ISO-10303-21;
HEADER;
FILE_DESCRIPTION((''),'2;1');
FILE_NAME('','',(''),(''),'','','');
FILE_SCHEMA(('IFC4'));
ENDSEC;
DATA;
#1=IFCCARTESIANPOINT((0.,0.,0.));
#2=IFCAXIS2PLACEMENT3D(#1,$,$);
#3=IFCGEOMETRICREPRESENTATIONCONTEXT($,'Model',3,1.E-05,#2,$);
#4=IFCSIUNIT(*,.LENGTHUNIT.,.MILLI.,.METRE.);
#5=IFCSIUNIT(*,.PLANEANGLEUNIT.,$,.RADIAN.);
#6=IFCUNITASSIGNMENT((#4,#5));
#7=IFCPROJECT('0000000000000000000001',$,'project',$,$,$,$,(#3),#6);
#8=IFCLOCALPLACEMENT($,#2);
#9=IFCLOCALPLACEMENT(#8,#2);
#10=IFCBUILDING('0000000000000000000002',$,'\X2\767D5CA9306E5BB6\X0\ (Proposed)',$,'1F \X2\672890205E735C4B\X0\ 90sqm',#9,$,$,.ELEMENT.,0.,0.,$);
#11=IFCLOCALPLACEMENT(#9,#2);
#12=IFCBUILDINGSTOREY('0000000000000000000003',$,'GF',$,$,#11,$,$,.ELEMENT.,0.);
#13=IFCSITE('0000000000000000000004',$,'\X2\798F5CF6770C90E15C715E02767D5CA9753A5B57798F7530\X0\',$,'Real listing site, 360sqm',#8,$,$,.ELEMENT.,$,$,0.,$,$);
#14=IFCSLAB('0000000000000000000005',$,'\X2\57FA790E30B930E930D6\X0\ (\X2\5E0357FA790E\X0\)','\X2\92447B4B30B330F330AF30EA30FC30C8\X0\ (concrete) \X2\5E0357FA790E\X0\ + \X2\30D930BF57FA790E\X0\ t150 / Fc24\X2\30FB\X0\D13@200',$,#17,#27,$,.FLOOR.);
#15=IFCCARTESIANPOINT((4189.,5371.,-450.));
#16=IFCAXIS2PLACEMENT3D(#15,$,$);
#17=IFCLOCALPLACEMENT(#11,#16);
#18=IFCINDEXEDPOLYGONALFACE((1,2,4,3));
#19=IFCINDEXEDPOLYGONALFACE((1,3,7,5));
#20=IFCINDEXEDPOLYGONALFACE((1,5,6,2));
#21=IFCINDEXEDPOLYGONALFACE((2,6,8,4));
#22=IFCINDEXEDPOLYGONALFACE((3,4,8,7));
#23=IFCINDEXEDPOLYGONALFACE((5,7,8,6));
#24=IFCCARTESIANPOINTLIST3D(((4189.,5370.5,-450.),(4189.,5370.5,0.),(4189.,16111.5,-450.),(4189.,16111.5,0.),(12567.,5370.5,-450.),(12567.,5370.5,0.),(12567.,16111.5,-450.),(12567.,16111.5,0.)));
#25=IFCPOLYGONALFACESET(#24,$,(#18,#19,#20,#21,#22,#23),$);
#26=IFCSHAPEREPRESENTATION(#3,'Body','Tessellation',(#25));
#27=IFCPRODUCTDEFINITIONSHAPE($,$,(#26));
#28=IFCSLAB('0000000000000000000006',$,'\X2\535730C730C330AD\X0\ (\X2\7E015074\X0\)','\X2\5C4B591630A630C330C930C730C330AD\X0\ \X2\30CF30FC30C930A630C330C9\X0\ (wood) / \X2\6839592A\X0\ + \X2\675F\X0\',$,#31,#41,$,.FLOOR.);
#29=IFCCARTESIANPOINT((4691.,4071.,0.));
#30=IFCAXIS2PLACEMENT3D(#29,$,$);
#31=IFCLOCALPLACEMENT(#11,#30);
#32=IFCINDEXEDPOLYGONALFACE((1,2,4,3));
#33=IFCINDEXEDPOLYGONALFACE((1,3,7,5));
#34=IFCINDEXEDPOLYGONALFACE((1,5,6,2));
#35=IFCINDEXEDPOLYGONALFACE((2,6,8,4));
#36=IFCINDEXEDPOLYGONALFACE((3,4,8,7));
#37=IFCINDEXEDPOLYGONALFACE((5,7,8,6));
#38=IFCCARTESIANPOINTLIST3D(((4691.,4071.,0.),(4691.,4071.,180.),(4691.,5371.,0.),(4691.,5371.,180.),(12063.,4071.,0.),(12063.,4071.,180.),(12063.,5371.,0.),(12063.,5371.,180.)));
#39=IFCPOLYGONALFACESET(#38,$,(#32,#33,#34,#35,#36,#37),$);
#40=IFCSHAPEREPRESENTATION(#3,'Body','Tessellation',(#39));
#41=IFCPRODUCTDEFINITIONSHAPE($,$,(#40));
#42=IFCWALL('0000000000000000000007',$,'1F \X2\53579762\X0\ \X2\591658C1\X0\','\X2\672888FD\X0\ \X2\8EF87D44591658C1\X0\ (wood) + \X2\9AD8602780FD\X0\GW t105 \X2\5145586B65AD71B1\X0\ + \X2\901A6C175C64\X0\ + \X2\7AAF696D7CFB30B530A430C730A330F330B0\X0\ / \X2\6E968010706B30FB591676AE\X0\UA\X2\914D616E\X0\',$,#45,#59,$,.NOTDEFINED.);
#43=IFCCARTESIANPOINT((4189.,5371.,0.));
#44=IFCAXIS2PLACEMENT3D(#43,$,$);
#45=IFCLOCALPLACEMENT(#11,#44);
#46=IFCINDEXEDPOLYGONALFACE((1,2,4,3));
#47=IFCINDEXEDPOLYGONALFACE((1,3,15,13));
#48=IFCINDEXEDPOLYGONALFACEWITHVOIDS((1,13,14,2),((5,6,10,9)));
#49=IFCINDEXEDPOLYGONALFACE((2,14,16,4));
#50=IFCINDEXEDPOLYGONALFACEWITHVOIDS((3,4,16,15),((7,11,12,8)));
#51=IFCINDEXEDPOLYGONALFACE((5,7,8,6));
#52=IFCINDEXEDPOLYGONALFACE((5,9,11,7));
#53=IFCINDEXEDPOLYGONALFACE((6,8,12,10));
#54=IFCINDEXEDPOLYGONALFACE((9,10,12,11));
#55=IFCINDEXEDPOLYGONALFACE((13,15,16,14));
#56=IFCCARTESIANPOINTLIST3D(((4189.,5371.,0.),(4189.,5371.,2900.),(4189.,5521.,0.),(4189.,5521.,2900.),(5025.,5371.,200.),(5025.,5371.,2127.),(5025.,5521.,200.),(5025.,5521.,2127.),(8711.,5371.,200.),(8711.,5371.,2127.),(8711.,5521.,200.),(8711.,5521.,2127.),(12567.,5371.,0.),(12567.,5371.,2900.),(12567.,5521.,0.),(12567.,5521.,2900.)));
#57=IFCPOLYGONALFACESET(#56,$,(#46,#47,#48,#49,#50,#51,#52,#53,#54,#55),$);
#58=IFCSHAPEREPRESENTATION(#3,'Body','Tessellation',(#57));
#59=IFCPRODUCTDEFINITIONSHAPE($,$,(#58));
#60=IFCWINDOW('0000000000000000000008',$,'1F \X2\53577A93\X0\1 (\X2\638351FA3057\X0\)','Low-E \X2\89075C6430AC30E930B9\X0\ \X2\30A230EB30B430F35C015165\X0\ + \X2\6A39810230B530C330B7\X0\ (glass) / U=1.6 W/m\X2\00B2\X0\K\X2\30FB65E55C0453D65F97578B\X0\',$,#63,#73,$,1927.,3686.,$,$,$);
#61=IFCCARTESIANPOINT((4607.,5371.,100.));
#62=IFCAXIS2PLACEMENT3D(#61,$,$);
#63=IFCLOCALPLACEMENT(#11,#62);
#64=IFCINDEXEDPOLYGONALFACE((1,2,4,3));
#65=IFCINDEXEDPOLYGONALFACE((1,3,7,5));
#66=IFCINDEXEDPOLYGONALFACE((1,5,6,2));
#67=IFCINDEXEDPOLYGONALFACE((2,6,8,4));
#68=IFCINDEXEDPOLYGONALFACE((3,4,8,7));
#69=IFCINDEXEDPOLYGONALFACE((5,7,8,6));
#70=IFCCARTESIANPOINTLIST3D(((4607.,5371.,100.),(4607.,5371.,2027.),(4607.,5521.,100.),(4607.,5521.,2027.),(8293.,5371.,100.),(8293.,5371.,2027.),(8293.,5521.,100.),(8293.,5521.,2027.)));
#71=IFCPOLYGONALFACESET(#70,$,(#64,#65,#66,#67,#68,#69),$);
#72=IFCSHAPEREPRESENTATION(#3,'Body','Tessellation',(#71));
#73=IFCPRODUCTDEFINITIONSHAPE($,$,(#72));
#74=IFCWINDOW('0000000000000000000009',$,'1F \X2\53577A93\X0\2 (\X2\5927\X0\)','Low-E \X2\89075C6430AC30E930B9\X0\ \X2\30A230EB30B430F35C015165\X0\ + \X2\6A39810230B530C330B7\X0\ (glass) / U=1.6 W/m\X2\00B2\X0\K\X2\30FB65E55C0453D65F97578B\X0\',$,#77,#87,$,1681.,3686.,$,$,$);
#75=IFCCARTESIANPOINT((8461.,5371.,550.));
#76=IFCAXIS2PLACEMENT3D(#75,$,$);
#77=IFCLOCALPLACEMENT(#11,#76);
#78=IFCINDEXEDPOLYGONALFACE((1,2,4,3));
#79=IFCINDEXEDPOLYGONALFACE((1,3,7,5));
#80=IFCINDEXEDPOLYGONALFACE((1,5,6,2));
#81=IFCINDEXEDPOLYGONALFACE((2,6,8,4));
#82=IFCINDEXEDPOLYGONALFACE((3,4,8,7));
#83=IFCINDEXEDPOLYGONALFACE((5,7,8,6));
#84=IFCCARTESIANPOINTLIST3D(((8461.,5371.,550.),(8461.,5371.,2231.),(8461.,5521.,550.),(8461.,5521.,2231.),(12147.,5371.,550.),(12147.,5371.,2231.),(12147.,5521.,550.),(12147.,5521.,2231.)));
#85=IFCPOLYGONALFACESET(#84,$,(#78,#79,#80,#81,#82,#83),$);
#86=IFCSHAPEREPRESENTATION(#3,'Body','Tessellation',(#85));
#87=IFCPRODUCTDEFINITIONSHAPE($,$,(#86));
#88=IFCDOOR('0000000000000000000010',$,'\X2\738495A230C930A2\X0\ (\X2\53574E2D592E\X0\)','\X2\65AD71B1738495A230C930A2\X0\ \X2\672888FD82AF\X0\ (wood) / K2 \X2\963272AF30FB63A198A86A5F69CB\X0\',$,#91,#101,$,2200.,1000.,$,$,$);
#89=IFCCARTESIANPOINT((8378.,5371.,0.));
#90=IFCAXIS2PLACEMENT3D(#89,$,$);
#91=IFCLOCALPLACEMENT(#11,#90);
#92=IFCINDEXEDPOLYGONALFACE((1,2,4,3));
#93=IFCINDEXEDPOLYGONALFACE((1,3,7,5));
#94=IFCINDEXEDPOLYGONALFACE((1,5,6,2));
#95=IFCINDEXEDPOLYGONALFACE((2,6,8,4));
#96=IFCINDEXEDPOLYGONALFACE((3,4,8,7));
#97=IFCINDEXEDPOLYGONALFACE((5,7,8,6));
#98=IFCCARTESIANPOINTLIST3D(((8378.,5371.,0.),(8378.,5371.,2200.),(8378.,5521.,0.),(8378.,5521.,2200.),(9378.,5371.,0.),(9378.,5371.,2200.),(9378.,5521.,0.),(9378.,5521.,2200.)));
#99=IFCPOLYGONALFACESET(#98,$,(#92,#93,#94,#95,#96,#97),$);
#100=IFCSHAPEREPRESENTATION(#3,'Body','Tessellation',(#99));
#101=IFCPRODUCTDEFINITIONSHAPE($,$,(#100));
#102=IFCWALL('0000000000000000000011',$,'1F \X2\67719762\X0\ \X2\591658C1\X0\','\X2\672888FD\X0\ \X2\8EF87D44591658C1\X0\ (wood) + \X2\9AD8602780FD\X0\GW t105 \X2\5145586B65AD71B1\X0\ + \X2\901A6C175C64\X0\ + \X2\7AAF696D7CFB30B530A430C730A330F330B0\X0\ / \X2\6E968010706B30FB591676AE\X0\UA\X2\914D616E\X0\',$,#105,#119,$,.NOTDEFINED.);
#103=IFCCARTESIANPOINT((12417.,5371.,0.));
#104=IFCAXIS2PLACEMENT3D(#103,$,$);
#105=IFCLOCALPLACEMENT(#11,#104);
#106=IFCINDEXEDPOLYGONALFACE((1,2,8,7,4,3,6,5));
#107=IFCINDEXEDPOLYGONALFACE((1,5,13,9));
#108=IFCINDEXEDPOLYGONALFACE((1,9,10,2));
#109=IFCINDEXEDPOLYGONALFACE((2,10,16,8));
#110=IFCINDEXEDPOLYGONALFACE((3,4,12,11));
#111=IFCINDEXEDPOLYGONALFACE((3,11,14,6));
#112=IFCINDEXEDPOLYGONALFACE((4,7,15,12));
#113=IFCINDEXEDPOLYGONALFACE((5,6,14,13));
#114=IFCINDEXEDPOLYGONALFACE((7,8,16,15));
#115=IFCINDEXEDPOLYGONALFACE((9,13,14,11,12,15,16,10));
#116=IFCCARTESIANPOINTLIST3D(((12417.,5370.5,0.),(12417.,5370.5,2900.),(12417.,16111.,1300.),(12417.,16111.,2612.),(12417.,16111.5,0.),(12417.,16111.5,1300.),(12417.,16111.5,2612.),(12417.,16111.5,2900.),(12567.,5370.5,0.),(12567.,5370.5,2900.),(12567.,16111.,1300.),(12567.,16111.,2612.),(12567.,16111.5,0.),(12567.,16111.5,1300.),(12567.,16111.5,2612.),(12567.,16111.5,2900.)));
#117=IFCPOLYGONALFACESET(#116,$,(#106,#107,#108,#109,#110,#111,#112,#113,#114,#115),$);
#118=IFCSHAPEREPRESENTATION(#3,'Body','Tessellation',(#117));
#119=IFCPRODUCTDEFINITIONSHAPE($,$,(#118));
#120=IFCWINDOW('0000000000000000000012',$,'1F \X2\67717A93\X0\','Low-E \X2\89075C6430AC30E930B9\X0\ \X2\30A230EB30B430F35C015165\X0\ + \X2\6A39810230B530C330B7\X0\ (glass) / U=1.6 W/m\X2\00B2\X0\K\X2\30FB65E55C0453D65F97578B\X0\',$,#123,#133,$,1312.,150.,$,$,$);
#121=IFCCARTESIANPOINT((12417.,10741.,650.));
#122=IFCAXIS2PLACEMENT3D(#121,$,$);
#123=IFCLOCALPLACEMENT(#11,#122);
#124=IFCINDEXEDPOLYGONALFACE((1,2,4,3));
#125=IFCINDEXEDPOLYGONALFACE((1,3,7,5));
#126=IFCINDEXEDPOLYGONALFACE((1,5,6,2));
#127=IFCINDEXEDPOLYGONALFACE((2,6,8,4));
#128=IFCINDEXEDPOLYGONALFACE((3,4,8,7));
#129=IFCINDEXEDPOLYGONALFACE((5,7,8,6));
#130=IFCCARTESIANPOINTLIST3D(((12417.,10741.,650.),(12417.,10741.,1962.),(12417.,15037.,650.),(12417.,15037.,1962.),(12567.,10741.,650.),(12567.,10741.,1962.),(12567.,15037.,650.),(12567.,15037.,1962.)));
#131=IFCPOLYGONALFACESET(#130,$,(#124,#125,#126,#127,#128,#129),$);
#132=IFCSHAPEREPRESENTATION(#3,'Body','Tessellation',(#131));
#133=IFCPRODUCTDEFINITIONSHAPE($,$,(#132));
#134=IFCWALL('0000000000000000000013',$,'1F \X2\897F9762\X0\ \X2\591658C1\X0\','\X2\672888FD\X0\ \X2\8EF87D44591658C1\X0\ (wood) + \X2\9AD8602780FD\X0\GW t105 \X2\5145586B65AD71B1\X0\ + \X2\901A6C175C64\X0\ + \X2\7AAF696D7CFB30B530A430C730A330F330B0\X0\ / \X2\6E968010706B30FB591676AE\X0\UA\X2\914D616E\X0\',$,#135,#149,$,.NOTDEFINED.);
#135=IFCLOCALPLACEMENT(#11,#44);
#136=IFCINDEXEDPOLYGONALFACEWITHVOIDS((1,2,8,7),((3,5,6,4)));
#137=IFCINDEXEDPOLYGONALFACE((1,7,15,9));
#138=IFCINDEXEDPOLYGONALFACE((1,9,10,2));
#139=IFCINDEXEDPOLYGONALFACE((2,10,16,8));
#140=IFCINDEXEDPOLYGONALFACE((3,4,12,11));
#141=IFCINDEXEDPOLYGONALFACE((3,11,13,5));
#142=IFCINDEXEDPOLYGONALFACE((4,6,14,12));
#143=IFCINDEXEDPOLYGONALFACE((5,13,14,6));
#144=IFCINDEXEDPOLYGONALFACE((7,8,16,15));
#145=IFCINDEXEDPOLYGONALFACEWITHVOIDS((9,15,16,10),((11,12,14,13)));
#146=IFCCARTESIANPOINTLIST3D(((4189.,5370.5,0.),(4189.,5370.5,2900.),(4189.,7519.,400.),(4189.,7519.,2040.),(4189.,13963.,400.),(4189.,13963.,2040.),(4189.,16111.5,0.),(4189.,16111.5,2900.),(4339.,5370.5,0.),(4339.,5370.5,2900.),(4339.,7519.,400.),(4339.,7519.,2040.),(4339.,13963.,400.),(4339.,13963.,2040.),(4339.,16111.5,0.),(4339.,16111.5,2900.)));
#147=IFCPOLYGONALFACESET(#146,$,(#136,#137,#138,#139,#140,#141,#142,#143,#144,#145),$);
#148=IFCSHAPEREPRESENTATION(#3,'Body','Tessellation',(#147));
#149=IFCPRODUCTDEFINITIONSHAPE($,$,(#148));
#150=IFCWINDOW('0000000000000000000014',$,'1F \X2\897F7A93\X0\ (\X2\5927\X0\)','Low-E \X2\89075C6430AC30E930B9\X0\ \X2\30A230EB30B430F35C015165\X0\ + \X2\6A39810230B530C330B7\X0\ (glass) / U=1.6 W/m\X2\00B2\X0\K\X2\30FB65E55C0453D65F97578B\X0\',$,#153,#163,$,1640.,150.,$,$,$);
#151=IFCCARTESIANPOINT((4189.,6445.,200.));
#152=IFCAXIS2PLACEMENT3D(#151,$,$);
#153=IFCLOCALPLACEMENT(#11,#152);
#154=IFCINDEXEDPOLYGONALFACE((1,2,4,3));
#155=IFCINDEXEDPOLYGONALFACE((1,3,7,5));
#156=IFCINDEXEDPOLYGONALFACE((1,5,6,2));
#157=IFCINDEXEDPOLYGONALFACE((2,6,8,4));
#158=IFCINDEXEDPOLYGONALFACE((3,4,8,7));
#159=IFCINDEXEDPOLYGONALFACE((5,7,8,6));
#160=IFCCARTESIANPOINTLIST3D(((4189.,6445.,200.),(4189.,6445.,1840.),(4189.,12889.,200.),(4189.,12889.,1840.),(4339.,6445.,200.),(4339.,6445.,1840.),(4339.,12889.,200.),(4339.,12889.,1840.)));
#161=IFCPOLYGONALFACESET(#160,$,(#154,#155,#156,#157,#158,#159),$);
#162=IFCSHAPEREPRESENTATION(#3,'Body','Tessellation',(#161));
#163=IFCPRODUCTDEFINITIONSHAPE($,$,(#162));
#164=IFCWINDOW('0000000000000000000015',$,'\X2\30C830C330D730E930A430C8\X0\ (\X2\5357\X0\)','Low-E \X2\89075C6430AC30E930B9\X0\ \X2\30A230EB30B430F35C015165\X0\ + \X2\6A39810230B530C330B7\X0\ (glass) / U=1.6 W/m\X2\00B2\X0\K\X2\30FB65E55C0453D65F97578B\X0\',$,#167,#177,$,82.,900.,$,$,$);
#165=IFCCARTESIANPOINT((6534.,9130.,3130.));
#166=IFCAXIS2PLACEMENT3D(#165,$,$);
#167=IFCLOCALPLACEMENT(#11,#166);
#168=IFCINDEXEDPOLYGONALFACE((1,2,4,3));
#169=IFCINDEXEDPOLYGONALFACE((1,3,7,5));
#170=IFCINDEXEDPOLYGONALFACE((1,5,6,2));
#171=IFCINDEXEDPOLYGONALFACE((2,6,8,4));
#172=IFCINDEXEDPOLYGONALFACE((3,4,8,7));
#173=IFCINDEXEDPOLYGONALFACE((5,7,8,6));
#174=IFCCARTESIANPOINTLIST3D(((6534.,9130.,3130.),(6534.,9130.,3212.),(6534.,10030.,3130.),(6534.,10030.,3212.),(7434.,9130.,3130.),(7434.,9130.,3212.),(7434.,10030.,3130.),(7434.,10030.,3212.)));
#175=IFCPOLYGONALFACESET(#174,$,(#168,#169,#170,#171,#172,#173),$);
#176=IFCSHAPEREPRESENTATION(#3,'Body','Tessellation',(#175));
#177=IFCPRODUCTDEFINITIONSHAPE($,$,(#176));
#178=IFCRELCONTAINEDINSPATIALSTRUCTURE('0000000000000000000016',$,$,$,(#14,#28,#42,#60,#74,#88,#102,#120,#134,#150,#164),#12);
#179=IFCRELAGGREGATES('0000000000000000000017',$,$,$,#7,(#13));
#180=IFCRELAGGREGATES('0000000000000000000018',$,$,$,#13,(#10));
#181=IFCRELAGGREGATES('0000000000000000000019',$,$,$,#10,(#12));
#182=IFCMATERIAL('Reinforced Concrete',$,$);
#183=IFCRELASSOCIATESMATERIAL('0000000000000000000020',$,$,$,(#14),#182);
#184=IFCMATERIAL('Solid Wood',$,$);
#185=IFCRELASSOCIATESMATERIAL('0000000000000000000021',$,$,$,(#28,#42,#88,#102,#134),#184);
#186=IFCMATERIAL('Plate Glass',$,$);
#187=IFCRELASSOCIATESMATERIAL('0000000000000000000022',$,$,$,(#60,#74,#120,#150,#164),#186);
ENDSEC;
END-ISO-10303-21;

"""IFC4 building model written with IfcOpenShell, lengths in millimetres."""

from ifc_helpers import new_model, si_unit, frame, frame_2d, origin, place, context, project, spatial, rectangle, extrude, material, element, fill, save


model = new_model("IFC4")

# Units and contexts
model_context = context("Model", 3, precision=1e-05, world=origin())
ifc_project = project(units=[si_unit("LENGTHUNIT", "METRE", prefix="MILLI"), si_unit("PLANEANGLEUNIT", "RADIAN")], contexts=[model_context])

# Site, building, storey
site_placement = place(None, origin())
site = spatial("IfcSite", under=ifc_project, at=site_placement, Name="福島県郡山市白岩町字福田", ObjectType="Real listing site, 360sqm", CompositionType="ELEMENT", RefElevation=0.0)
building_placement = place(site_placement, origin())
building = spatial("IfcBuilding", under=site, at=building_placement, Name="白岩の家 (Proposed)", ObjectType="1F 木造平屋 90sqm", CompositionType="ELEMENT", ElevationOfRefHeight=0.0, ElevationOfTerrain=0.0)
storey_placement = place(building_placement, origin())
storey = spatial("IfcBuildingStorey", under=building, at=storey_placement, Name="GF", CompositionType="ELEMENT", Elevation=0.0)

# Slabs
ifc_material_1 = material(Name="Reinforced Concrete")
slab_1_placement = place(storey_placement, frame((4189.0, 5371.0, -450.0)))
element("IfcSlab", 1, at=slab_1_placement, inside=storey, material=ifc_material_1, Name="基礎スラブ (布基礎)", Description="鉄筋コンクリート (concrete) 布基礎 + ベタ基礎 t150 / Fc24・D13@200", PredefinedType="FLOOR", context=model_context, shape_type="SweptSolid", body=[
    extrude(rectangle(XDim=8378.0, YDim=10741.0, at=frame_2d((4189.0, 5370.0))), frame((4189.0, 5371.0, -450.0)), (0.0, 0.0, 1.0), 450.0),
])
ifc_material_2 = material(Name="Solid Wood")
slab_2_placement = place(storey_placement, frame((4691.0, 4071.0, 0.0)))
element("IfcSlab", 2, at=slab_2_placement, inside=storey, material=ifc_material_2, Name="南デッキ (縁側)", Description="屋外ウッドデッキ ハードウッド (wood) / 根太 + 束", PredefinedType="FLOOR", context=model_context, shape_type="SweptSolid", body=[
    extrude(rectangle(XDim=7372.0, YDim=1300.0, at=frame_2d((3686.0, 650.0))), frame((4691.0, 4071.0, 0.0)), (0.0, 0.0, 1.0), 180.0),
])

# Wall, openings, windows, door
wall_1_placement = place(storey_placement, frame((4189.0, 5371.0, 0.0)))
wall_1 = element("IfcWall", 3, at=wall_1_placement, inside=storey, material=ifc_material_2, Name="1F 南面 外壁", Description="木製 軸組外壁 (wood) + 高性能GW t105 充填断熱 + 通気層 + 窯業系サイディング / 準耐火・外皮UA配慮", PredefinedType="NOTDEFINED", context=model_context, shape_type="SweptSolid", body=[
    extrude(rectangle(XDim=8378.0, YDim=150.0, at=frame_2d((4189.0, 75.0))), frame((4189.0, 5371.0, 0.0)), (0.0, 0.0, 1.0), 2900.0),
])
opening_1_placement = place(storey_placement, frame((4607.0, 5371.0, 100.0)))
opening_1 = element("IfcOpeningElement", 4, at=opening_1_placement, cuts=wall_1, PredefinedType="NOTDEFINED", context=model_context, shape_type="SweptSolid", body=[
    extrude(rectangle(XDim=3686.0, YDim=150.0, at=frame_2d((1843.0, 75.0))), frame((4607.0, 5371.0, 100.0)), (0.0, 0.0, 1.0), 1927.0),
])
opening_2_placement = place(storey_placement, frame((8461.0, 5371.0, 550.0)))
opening_2 = element("IfcOpeningElement", 5, at=opening_2_placement, cuts=wall_1, PredefinedType="NOTDEFINED", context=model_context, shape_type="SweptSolid", body=[
    extrude(rectangle(XDim=3686.0, YDim=150.0, at=frame_2d((1843.0, 75.0))), frame((8461.0, 5371.0, 550.0)), (0.0, 0.0, 1.0), 1681.0),
])
opening_3_placement = place(storey_placement, frame((8378.0, 5371.0, 0.0)))
opening_3 = element("IfcOpeningElement", 6, at=opening_3_placement, cuts=wall_1, PredefinedType="NOTDEFINED", context=model_context, shape_type="SweptSolid", body=[
    extrude(rectangle(XDim=1000.0, YDim=150.0, at=frame_2d((500.0, 75.0))), frame((8378.0, 5371.0, 0.0)), (0.0, 0.0, 1.0), 2200.0),
])
ifc_material_3 = material(Name="Plate Glass")
window_1_placement = place(storey_placement, frame((4607.0, 5371.0, 100.0)))
window_1 = element("IfcWindow", 7, at=window_1_placement, inside=storey, material=ifc_material_3, Name="1F 南窓1 (掃出し)", Description="Low-E 複層ガラス アルゴン封入 + 樹脂サッシ (glass) / U=1.6 W/m²K・日射取得型", OverallHeight=1927.0, OverallWidth=3686.0, context=model_context, shape_type="SweptSolid", body=[
    extrude(rectangle(XDim=3686.0, YDim=150.0, at=frame_2d((1843.0, 75.0))), frame((4607.0, 5371.0, 100.0)), (0.0, 0.0, 1.0), 1927.0),
])
fill(opening_1, window_1)
window_2_placement = place(storey_placement, frame((8461.0, 5371.0, 550.0)))
window_2 = element("IfcWindow", 8, at=window_2_placement, inside=storey, material=ifc_material_3, Name="1F 南窓2 (大)", Description="Low-E 複層ガラス アルゴン封入 + 樹脂サッシ (glass) / U=1.6 W/m²K・日射取得型", OverallHeight=1681.0, OverallWidth=3686.0, context=model_context, shape_type="SweptSolid", body=[
    extrude(rectangle(XDim=3686.0, YDim=150.0, at=frame_2d((1843.0, 75.0))), frame((8461.0, 5371.0, 550.0)), (0.0, 0.0, 1.0), 1681.0),
])
fill(opening_2, window_2)
door_placement = place(storey_placement, frame((8378.0, 5371.0, 0.0)))
door = element("IfcDoor", 9, at=door_placement, inside=storey, material=ifc_material_2, Name="玄関ドア (南中央)", Description="断熱玄関ドア 木製芯 (wood) / K2 防犯・採風機構", OverallHeight=2200.0, OverallWidth=1000.0, context=model_context, shape_type="SweptSolid", body=[
    extrude(rectangle(XDim=1000.0, YDim=150.0, at=frame_2d((500.0, 75.0))), frame((8378.0, 5371.0, 0.0)), (0.0, 0.0, 1.0), 2200.0),
])
fill(opening_3, door)

# Walls, openings, windows
wall_2_placement = place(storey_placement, frame((12417.0, 5371.0, 0.0)))
wall_2 = element("IfcWall", 10, at=wall_2_placement, inside=storey, material=ifc_material_2, Name="1F 東面 外壁", Description="木製 軸組外壁 (wood) + 高性能GW t105 充填断熱 + 通気層 + 窯業系サイディング / 準耐火・外皮UA配慮", PredefinedType="NOTDEFINED", context=model_context, shape_type="SweptSolid", body=[
    extrude(rectangle(XDim=150.0, YDim=10741.0, at=frame_2d((75.0, 5370.0))), frame((12417.0, 5371.0, 0.0)), (0.0, 0.0, 1.0), 2900.0),
])
opening_4_placement = place(storey_placement, frame((12417.0, 10741.0, 650.0)))
opening_4 = element("IfcOpeningElement", 11, at=opening_4_placement, cuts=wall_2, PredefinedType="NOTDEFINED", context=model_context, shape_type="SweptSolid", body=[
    extrude(rectangle(XDim=150.0, YDim=4296.0, at=frame_2d((75.0, 2148.0))), frame((12417.0, 10741.0, 650.0)), (0.0, 0.0, 1.0), 1312.0),
])
window_3_placement = place(storey_placement, frame((12417.0, 10741.0, 650.0)))
window_3 = element("IfcWindow", 12, at=window_3_placement, inside=storey, material=ifc_material_3, Name="1F 東窓", Description="Low-E 複層ガラス アルゴン封入 + 樹脂サッシ (glass) / U=1.6 W/m²K・日射取得型", OverallHeight=1312.0, OverallWidth=150.0, context=model_context, shape_type="SweptSolid", body=[
    extrude(rectangle(XDim=150.0, YDim=4296.0, at=frame_2d((75.0, 2148.0))), frame((12417.0, 10741.0, 650.0)), (0.0, 0.0, 1.0), 1312.0),
])
fill(opening_4, window_3)
wall_3_placement = place(storey_placement, frame((4189.0, 5371.0, 0.0)))
wall_3 = element("IfcWall", 13, at=wall_3_placement, inside=storey, material=ifc_material_2, Name="1F 西面 外壁", Description="木製 軸組外壁 (wood) + 高性能GW t105 充填断熱 + 通気層 + 窯業系サイディング / 準耐火・外皮UA配慮", PredefinedType="NOTDEFINED", context=model_context, shape_type="SweptSolid", body=[
    extrude(rectangle(XDim=150.0, YDim=10741.0, at=frame_2d((75.0, 5370.0))), frame((4189.0, 5371.0, 0.0)), (0.0, 0.0, 1.0), 2900.0),
])
opening_5_placement = place(storey_placement, frame((4189.0, 6445.0, 200.0)))
opening_5 = element("IfcOpeningElement", 14, at=opening_5_placement, cuts=wall_3, PredefinedType="NOTDEFINED", context=model_context, shape_type="SweptSolid", body=[
    extrude(rectangle(XDim=150.0, YDim=6444.0, at=frame_2d((75.0, 3222.0))), frame((4189.0, 6445.0, 200.0)), (0.0, 0.0, 1.0), 1640.0),
])
window_4_placement = place(storey_placement, frame((4189.0, 6445.0, 200.0)))
window_4 = element("IfcWindow", 15, at=window_4_placement, inside=storey, material=ifc_material_3, Name="1F 西窓 (大)", Description="Low-E 複層ガラス アルゴン封入 + 樹脂サッシ (glass) / U=1.6 W/m²K・日射取得型", OverallHeight=1640.0, OverallWidth=150.0, context=model_context, shape_type="SweptSolid", body=[
    extrude(rectangle(XDim=150.0, YDim=6444.0, at=frame_2d((75.0, 3222.0))), frame((4189.0, 6445.0, 200.0)), (0.0, 0.0, 1.0), 1640.0),
])
fill(opening_5, window_4)

# Window
window_5_placement = place(storey_placement, frame((6534.0, 9130.0, 3130.0)))
element("IfcWindow", 16, at=window_5_placement, inside=storey, material=ifc_material_3, Name="トップライト (南)", Description="Low-E 複層ガラス アルゴン封入 + 樹脂サッシ (glass) / U=1.6 W/m²K・日射取得型", OverallHeight=82.0, OverallWidth=900.0, context=model_context, shape_type="SweptSolid", body=[
    extrude(rectangle(XDim=900.0, YDim=900.0, at=frame_2d((450.0, 450.0))), frame((6534.0, 9130.0, 3130.0)), (0.0, 0.0, 1.0), 82.0),
])

save(model, "model.ifc")
